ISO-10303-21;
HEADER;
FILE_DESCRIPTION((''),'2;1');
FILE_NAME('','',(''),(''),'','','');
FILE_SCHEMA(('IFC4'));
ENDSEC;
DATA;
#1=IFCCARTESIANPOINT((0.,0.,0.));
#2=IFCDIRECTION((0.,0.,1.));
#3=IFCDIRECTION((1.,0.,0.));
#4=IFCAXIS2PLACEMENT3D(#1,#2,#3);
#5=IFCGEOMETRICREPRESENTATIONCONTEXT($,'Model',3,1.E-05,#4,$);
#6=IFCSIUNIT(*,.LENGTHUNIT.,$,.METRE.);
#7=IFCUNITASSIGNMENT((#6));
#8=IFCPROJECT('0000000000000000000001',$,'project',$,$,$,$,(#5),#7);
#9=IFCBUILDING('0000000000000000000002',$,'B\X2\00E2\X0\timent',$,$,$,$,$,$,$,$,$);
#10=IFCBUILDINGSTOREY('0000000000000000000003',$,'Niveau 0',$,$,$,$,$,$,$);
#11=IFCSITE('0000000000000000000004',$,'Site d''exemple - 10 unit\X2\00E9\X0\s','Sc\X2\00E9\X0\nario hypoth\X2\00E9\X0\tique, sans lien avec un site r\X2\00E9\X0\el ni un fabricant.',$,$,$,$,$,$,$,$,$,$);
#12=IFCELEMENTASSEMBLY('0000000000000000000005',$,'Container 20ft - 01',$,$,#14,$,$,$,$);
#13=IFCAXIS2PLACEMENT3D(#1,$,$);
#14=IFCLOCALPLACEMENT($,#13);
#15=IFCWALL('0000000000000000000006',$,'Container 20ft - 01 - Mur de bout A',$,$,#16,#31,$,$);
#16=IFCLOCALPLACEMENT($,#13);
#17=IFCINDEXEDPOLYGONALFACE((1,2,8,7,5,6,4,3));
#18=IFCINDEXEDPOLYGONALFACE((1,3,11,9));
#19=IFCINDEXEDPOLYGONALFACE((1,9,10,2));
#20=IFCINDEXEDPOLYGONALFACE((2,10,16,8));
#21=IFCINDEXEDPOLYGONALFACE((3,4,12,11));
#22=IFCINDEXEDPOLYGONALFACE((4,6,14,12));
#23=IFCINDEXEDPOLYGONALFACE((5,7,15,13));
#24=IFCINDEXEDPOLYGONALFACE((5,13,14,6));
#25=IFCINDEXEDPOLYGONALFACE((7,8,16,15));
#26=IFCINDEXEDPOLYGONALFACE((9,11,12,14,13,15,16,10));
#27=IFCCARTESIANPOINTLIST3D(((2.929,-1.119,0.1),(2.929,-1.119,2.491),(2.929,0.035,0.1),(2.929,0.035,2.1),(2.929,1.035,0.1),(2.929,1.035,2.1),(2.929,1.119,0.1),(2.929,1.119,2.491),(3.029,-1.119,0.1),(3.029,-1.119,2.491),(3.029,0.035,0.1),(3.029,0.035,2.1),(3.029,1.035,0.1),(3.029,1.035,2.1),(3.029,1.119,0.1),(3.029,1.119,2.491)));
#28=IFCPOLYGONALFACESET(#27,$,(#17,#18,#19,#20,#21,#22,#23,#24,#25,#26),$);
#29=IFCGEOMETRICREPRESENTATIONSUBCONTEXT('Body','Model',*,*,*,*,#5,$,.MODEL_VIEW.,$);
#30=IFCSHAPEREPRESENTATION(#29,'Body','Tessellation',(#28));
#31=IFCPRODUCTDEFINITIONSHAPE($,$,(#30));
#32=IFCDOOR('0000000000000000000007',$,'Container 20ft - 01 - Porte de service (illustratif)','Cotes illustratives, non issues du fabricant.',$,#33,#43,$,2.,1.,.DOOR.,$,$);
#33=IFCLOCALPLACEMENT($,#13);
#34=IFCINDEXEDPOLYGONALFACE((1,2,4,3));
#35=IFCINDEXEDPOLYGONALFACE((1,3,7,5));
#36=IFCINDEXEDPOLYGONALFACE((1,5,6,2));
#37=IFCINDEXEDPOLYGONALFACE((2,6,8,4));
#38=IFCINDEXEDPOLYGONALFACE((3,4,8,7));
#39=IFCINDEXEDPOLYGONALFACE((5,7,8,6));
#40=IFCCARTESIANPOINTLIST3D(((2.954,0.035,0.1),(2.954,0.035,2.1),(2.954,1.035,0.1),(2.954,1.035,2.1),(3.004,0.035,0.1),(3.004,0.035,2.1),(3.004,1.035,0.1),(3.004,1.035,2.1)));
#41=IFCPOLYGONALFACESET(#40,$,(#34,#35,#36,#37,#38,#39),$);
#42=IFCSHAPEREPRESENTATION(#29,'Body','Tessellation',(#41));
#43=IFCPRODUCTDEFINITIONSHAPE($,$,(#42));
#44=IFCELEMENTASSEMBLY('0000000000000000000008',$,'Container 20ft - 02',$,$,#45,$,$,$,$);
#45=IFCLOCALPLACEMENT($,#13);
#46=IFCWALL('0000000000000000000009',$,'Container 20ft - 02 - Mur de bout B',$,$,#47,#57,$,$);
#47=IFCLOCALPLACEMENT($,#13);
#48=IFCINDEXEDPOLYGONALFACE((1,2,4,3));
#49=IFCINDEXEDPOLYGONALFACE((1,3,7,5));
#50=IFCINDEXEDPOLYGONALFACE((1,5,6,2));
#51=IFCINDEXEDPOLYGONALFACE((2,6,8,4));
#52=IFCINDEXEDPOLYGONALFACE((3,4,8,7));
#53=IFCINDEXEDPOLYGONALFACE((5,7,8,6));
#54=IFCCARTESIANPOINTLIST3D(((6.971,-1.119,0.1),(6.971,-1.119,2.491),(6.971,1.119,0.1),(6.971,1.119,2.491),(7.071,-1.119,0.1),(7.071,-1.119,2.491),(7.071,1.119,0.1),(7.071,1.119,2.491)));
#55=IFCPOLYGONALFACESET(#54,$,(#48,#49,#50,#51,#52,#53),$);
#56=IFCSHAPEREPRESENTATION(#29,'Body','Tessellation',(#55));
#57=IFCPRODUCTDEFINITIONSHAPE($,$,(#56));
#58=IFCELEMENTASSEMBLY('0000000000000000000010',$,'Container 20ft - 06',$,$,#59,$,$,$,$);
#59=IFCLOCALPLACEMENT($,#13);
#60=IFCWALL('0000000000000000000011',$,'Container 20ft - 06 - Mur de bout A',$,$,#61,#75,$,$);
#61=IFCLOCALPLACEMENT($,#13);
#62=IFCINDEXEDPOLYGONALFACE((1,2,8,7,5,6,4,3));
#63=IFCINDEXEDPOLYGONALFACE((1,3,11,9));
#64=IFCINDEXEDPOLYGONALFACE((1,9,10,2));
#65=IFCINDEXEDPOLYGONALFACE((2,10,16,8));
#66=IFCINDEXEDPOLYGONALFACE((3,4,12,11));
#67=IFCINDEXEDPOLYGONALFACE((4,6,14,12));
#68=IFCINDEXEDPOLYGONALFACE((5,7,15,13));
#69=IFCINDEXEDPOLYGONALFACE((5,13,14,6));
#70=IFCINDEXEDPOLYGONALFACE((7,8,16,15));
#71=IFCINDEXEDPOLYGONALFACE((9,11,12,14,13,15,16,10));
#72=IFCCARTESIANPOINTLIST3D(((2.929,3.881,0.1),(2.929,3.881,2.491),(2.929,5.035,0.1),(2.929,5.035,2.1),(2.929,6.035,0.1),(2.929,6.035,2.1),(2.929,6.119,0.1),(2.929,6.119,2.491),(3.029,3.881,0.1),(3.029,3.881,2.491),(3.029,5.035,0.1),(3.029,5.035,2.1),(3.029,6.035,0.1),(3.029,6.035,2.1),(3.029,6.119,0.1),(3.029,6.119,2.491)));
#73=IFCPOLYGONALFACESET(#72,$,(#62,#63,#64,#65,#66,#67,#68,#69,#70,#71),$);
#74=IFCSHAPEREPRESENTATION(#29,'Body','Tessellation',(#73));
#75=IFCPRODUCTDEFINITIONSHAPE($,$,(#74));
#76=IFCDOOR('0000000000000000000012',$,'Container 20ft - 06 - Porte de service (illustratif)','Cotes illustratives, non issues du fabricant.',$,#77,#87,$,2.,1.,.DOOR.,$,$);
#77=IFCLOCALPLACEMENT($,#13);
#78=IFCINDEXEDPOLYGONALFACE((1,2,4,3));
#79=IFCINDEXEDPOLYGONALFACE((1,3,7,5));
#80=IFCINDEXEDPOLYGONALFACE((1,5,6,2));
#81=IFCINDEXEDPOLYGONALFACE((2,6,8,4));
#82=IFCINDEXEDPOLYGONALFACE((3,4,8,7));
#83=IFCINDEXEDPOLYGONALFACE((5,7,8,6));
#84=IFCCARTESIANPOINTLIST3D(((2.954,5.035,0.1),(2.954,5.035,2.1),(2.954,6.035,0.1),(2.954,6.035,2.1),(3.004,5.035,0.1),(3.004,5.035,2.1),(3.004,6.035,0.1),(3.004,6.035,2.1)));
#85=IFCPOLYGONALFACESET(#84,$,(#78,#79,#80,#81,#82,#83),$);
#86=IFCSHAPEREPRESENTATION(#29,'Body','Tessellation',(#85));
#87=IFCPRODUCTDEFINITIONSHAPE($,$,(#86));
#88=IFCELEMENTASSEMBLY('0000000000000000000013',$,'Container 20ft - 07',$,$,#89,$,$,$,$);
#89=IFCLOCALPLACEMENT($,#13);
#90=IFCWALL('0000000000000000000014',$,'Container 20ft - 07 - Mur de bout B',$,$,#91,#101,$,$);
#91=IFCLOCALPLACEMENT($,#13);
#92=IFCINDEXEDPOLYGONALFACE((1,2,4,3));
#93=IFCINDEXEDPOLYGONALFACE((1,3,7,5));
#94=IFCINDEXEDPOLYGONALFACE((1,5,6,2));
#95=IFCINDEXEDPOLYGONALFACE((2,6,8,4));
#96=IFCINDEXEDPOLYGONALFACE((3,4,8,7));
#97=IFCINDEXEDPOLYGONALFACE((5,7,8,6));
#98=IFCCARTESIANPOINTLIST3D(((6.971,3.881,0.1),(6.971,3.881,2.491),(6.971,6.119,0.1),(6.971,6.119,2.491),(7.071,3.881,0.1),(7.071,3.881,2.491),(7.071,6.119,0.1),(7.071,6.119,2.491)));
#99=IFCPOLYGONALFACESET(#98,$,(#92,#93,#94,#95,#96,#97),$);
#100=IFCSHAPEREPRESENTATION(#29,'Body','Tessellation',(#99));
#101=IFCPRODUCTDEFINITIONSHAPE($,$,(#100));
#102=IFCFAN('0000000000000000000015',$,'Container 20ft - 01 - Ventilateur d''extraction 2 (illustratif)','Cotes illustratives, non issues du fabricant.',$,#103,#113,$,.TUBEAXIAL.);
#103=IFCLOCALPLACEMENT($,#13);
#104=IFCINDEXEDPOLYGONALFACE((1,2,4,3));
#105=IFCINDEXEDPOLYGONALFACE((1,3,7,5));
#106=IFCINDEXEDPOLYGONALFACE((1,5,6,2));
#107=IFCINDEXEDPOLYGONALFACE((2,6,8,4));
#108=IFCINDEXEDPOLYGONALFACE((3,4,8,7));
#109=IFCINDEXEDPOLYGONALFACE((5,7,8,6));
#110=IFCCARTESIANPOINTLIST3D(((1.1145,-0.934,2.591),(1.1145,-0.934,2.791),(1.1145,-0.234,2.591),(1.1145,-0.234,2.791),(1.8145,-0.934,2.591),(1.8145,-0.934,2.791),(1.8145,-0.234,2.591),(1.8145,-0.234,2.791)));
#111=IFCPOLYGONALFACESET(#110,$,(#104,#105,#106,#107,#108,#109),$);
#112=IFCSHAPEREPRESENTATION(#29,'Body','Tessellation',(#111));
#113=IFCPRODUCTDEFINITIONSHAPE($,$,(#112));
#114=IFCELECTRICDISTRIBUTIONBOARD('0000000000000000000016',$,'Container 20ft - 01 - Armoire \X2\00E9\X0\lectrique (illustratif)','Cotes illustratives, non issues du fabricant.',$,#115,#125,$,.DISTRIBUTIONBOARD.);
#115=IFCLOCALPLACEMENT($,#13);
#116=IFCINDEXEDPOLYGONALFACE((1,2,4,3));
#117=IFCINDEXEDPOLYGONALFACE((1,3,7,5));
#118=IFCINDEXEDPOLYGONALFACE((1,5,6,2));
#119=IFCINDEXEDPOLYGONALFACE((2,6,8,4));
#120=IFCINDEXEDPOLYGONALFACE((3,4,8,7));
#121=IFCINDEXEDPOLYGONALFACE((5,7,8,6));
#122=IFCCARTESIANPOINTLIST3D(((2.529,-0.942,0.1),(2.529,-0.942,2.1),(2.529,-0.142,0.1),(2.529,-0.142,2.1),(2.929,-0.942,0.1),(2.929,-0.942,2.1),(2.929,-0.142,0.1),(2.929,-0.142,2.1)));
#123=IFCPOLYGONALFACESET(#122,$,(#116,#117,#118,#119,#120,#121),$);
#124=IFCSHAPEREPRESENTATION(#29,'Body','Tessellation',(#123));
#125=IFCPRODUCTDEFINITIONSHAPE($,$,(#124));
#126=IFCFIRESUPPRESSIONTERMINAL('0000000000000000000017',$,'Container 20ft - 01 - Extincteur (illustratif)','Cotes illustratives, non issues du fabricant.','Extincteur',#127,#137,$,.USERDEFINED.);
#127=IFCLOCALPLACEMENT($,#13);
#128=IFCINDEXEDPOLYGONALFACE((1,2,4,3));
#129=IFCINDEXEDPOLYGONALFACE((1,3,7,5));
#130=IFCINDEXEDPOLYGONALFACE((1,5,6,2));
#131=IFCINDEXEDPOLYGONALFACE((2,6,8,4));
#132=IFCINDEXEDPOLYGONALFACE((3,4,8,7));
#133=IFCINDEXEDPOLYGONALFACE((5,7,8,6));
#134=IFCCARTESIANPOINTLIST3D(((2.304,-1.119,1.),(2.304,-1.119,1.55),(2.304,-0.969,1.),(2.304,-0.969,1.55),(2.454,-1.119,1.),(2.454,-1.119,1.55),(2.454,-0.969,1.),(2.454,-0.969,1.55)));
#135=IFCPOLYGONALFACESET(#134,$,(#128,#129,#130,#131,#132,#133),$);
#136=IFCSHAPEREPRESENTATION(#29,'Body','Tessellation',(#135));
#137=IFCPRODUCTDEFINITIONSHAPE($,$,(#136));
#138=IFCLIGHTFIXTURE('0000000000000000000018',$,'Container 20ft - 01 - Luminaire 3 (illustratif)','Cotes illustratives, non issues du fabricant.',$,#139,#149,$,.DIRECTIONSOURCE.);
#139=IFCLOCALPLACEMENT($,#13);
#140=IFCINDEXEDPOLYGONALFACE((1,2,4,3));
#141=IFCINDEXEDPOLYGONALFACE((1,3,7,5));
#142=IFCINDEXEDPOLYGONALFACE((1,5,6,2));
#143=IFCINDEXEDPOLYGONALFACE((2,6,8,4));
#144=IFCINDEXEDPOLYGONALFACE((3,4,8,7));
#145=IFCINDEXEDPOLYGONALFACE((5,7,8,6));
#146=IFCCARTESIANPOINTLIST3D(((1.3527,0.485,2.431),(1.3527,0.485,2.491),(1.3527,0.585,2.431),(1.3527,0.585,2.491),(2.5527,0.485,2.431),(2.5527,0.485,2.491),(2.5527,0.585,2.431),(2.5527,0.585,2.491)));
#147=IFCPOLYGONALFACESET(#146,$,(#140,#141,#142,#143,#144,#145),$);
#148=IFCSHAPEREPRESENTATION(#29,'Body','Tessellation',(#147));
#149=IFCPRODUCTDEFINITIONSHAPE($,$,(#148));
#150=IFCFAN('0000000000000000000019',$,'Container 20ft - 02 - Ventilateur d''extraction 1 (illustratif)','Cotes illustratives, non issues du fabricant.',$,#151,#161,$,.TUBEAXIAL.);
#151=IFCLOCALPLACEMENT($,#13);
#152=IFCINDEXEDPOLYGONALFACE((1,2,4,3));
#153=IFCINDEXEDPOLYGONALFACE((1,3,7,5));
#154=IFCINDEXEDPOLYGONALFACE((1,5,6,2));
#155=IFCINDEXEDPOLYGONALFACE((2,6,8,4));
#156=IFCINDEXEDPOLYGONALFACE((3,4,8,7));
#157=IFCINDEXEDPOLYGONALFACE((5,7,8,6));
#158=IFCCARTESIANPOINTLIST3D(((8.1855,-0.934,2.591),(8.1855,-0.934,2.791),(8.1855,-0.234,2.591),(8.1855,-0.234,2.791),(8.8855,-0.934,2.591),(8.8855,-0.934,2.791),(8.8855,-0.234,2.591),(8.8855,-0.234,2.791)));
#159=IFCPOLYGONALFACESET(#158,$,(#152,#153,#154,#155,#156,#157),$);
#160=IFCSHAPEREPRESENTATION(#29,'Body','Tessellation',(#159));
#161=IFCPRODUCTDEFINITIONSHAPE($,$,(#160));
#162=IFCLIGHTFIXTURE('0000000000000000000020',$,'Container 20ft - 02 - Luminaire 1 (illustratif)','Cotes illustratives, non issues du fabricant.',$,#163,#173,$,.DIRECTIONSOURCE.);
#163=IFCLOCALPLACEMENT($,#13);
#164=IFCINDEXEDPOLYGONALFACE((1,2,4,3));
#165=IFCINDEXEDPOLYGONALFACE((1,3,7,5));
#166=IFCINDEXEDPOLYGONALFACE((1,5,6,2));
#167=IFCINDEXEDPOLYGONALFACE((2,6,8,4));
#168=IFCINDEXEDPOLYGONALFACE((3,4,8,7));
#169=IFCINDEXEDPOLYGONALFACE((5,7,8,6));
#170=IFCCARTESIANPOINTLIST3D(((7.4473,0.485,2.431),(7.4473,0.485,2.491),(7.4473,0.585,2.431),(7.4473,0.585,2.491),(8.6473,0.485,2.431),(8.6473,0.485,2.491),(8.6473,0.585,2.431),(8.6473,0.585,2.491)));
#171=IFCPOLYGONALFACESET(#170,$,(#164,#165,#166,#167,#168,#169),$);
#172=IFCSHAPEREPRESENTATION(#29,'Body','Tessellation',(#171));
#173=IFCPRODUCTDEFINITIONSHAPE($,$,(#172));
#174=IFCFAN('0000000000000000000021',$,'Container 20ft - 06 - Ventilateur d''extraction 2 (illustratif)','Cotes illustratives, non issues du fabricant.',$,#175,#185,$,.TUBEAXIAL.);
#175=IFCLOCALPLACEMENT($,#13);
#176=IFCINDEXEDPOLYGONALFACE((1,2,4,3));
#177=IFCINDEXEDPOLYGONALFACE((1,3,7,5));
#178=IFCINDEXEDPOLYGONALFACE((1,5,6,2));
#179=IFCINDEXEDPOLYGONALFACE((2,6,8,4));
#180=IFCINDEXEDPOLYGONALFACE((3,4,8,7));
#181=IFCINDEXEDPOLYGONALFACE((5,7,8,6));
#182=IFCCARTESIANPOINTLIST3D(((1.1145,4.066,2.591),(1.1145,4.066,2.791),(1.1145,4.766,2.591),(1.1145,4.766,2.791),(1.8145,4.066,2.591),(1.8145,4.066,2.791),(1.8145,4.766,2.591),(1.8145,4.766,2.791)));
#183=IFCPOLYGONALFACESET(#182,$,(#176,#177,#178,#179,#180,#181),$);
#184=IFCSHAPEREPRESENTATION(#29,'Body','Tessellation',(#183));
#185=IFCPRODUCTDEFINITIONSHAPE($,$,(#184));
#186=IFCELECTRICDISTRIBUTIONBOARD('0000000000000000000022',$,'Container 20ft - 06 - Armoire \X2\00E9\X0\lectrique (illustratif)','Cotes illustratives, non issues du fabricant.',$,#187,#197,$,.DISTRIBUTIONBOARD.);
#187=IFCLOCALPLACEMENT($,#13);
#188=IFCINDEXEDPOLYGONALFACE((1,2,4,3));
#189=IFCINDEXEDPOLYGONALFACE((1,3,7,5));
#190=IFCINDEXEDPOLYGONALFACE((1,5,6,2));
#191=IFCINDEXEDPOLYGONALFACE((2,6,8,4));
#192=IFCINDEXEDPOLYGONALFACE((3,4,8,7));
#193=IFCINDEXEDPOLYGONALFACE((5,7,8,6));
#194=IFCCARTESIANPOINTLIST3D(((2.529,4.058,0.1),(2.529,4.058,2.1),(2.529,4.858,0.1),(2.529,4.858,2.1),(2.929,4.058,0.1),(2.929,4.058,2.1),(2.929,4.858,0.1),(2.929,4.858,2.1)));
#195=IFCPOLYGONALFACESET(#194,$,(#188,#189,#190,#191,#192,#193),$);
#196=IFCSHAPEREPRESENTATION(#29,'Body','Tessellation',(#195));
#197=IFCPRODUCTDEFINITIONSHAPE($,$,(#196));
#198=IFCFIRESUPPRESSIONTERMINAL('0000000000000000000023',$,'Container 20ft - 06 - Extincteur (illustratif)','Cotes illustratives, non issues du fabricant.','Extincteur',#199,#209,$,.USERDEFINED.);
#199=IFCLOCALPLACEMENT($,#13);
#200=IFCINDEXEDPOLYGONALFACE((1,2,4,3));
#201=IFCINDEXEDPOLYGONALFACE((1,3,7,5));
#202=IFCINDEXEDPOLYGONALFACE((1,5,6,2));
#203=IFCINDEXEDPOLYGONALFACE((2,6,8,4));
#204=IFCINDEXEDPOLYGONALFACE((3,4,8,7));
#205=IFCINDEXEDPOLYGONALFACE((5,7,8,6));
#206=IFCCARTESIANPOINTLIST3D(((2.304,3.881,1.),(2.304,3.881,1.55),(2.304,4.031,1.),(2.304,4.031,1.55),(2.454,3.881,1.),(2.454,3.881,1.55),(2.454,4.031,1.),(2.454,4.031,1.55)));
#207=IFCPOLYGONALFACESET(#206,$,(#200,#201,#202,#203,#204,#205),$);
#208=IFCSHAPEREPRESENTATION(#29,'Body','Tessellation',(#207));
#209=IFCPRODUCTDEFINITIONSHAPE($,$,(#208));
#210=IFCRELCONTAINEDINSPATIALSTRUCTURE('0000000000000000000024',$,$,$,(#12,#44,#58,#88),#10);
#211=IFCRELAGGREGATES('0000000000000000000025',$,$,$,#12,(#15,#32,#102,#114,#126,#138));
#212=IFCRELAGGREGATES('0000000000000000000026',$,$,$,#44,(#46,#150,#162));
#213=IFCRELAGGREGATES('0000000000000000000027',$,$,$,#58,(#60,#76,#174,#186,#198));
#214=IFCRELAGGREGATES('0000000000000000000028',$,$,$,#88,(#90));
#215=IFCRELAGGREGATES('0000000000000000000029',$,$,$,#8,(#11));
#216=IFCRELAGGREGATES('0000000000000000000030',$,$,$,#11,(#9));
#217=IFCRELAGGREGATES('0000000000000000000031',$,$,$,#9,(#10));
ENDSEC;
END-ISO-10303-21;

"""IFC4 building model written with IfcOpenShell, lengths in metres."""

from ifc_helpers import new_model, si_unit, frame, origin_with_axes, place, context, subcontext, project, spatial, rectangle, extrude, element, fill, aggregate, save


model = new_model("IFC4")

# Units and contexts
model_context = context("Model", 3, precision=1e-05, world=origin_with_axes())
body_context = subcontext(model_context, "Body", "Model", "MODEL_VIEW")
ifc_project = project(units=[si_unit("LENGTHUNIT", "METRE")], contexts=[model_context])

# Site, building, storey
site = spatial("IfcSite", under=ifc_project, Name="Site d'exemple - 10 unités", Description="Scénario hypothétique, sans lien avec un site réel ni un fabricant.")
building = spatial("IfcBuilding", under=site, Name="Bâtiment")
storey = spatial("IfcBuildingStorey", under=building, Name="Niveau 0")

# Element assembly, wall, opening, door
assembly_1 = element("IfcElementAssembly", 1, inside=storey, Name="Container 20ft - 01")
wall_1_placement = place(None, frame((2.979, 0.0, 0.1), z_axis=(0.0, 0.0, 1.0), x_axis=(1.0, 0.0, 0.0)))
wall_1 = element("IfcWall", 2, at=wall_1_placement, Name="Container 20ft - 01 - Mur de bout A", context=body_context, shape_type="SweptSolid", body=[
    extrude(rectangle(XDim=0.1, YDim=2.238), origin_with_axes(), (0.0, 0.0, 1.0), 2.391),
])
opening_1_placement = place(None, frame((2.979, 0.535, 0.1), z_axis=(0.0, 0.0, 1.0), x_axis=(1.0, 0.0, 0.0)))
opening_1 = element("IfcOpeningElement", 3, at=opening_1_placement, cuts=wall_1, PredefinedType="OPENING", context=body_context, shape_type="SweptSolid", body=[
    extrude(rectangle(XDim=0.2, YDim=1.0), origin_with_axes(), (0.0, 0.0, 1.0), 2.0),
])
door_1_placement = place(None, frame((2.979, 0.535, 0.1), z_axis=(0.0, 0.0, 1.0), x_axis=(1.0, 0.0, 0.0)))
door_1 = element("IfcDoor", 4, at=door_1_placement, Name="Container 20ft - 01 - Porte de service (illustratif)", Description="Cotes illustratives, non issues du fabricant.", OverallHeight=2.0, OverallWidth=1.0, PredefinedType="DOOR", context=body_context, shape_type="SweptSolid", body=[
    extrude(rectangle(XDim=0.05, YDim=1.0), origin_with_axes(), (0.0, 0.0, 1.0), 2.0),
])
fill(opening_1, door_1)

# Element assembly, wall
assembly_2 = element("IfcElementAssembly", 5, inside=storey, Name="Container 20ft - 02")
wall_2_placement = place(None, frame((7.021, 0.0, 0.1), z_axis=(0.0, 0.0, 1.0), x_axis=(1.0, 0.0, 0.0)))
wall_2 = element("IfcWall", 6, at=wall_2_placement, Name="Container 20ft - 02 - Mur de bout B", context=body_context, shape_type="SweptSolid", body=[
    extrude(rectangle(XDim=0.1, YDim=2.238), origin_with_axes(), (0.0, 0.0, 1.0), 2.391),
])

# Element assembly, wall, opening, door
assembly_3 = element("IfcElementAssembly", 7, inside=storey, Name="Container 20ft - 06")
wall_3_placement = place(None, frame((2.979, 5.0, 0.1), z_axis=(0.0, 0.0, 1.0), x_axis=(1.0, 0.0, 0.0)))
wall_3 = element("IfcWall", 8, at=wall_3_placement, Name="Container 20ft - 06 - Mur de bout A", context=body_context, shape_type="SweptSolid", body=[
    extrude(rectangle(XDim=0.1, YDim=2.238), origin_with_axes(), (0.0, 0.0, 1.0), 2.391),
])
opening_2_placement = place(None, frame((2.979, 5.535, 0.1), z_axis=(0.0, 0.0, 1.0), x_axis=(1.0, 0.0, 0.0)))
opening_2 = element("IfcOpeningElement", 9, at=opening_2_placement, cuts=wall_3, PredefinedType="OPENING", context=body_context, shape_type="SweptSolid", body=[
    extrude(rectangle(XDim=0.2, YDim=1.0), origin_with_axes(), (0.0, 0.0, 1.0), 2.0),
])
door_2_placement = place(None, frame((2.979, 5.535, 0.1), z_axis=(0.0, 0.0, 1.0), x_axis=(1.0, 0.0, 0.0)))
door_2 = element("IfcDoor", 10, at=door_2_placement, Name="Container 20ft - 06 - Porte de service (illustratif)", Description="Cotes illustratives, non issues du fabricant.", OverallHeight=2.0, OverallWidth=1.0, PredefinedType="DOOR", context=body_context, shape_type="SweptSolid", body=[
    extrude(rectangle(XDim=0.05, YDim=1.0), origin_with_axes(), (0.0, 0.0, 1.0), 2.0),
])
fill(opening_2, door_2)

# Element assembly, wall
assembly_4 = element("IfcElementAssembly", 11, inside=storey, Name="Container 20ft - 07")
wall_4_placement = place(None, frame((7.021, 5.0, 0.1), z_axis=(0.0, 0.0, 1.0), x_axis=(1.0, 0.0, 0.0)))
wall_4 = element("IfcWall", 12, at=wall_4_placement, Name="Container 20ft - 07 - Mur de bout B", context=body_context, shape_type="SweptSolid", body=[
    extrude(rectangle(XDim=0.1, YDim=2.238), origin_with_axes(), (0.0, 0.0, 1.0), 2.391),
])

# Fan
fan_1_placement = place(None, frame((1.4645, -0.584, 2.591), z_axis=(0.0, 0.0, 1.0), x_axis=(1.0, 0.0, 0.0)))
fan_1 = element("IfcFan", 13, at=fan_1_placement, Name="Container 20ft - 01 - Ventilateur d'extraction 2 (illustratif)", Description="Cotes illustratives, non issues du fabricant.", PredefinedType="TUBEAXIAL", context=body_context, shape_type="SweptSolid", body=[
    extrude(rectangle(XDim=0.7, YDim=0.7), origin_with_axes(), (0.0, 0.0, 1.0), 0.2),
])

# Electric distribution board
electric_distribution_board_1_placement = place(None, frame((2.729, -0.542, 0.1), z_axis=(0.0, 0.0, 1.0), x_axis=(1.0, 0.0, 0.0)))
electric_distribution_board_1 = element("IfcElectricDistributionBoard", 14, at=electric_distribution_board_1_placement, Name="Container 20ft - 01 - Armoire électrique (illustratif)", Description="Cotes illustratives, non issues du fabricant.", PredefinedType="DISTRIBUTIONBOARD", context=body_context, shape_type="SweptSolid", body=[
    extrude(rectangle(XDim=0.4, YDim=0.8), origin_with_axes(), (0.0, 0.0, 1.0), 2.0),
])

# Fire suppression terminal
fire_suppression_terminal_1_placement = place(None, frame((2.379, -1.044, 1.0), z_axis=(0.0, 0.0, 1.0), x_axis=(1.0, 0.0, 0.0)))
fire_suppression_terminal_1 = element("IfcFireSuppressionTerminal", 15, at=fire_suppression_terminal_1_placement, Name="Container 20ft - 01 - Extincteur (illustratif)", Description="Cotes illustratives, non issues du fabricant.", ObjectType="Extincteur", PredefinedType="USERDEFINED", context=body_context, shape_type="SweptSolid", body=[
    extrude(rectangle(XDim=0.15, YDim=0.15), origin_with_axes(), (0.0, 0.0, 1.0), 0.55),
])

# Light fixture
light_fixture_1_placement = place(None, frame((1.9527, 0.535, 2.431), z_axis=(0.0, 0.0, 1.0), x_axis=(1.0, 0.0, 0.0)))
light_fixture_1 = element("IfcLightFixture", 16, at=light_fixture_1_placement, Name="Container 20ft - 01 - Luminaire 3 (illustratif)", Description="Cotes illustratives, non issues du fabricant.", PredefinedType="DIRECTIONSOURCE", context=body_context, shape_type="SweptSolid", body=[
    extrude(rectangle(XDim=1.2, YDim=0.1), origin_with_axes(), (0.0, 0.0, 1.0), 0.06),
])

# Fan
fan_2_placement = place(None, frame((8.5355, -0.584, 2.591), z_axis=(0.0, 0.0, 1.0), x_axis=(1.0, 0.0, 0.0)))
fan_2 = element("IfcFan", 17, at=fan_2_placement, Name="Container 20ft - 02 - Ventilateur d'extraction 1 (illustratif)", Description="Cotes illustratives, non issues du fabricant.", PredefinedType="TUBEAXIAL", context=body_context, shape_type="SweptSolid", body=[
    extrude(rectangle(XDim=0.7, YDim=0.7), origin_with_axes(), (0.0, 0.0, 1.0), 0.2),
])

# Light fixture
light_fixture_2_placement = place(None, frame((8.0473, 0.535, 2.431), z_axis=(0.0, 0.0, 1.0), x_axis=(1.0, 0.0, 0.0)))
light_fixture_2 = element("IfcLightFixture", 18, at=light_fixture_2_placement, Name="Container 20ft - 02 - Luminaire 1 (illustratif)", Description="Cotes illustratives, non issues du fabricant.", PredefinedType="DIRECTIONSOURCE", context=body_context, shape_type="SweptSolid", body=[
    extrude(rectangle(XDim=1.2, YDim=0.1), origin_with_axes(), (0.0, 0.0, 1.0), 0.06),
])

# Fan
fan_3_placement = place(None, frame((1.4645, 4.416, 2.591), z_axis=(0.0, 0.0, 1.0), x_axis=(1.0, 0.0, 0.0)))
fan_3 = element("IfcFan", 19, at=fan_3_placement, Name="Container 20ft - 06 - Ventilateur d'extraction 2 (illustratif)", Description="Cotes illustratives, non issues du fabricant.", PredefinedType="TUBEAXIAL", context=body_context, shape_type="SweptSolid", body=[
    extrude(rectangle(XDim=0.7, YDim=0.7), origin_with_axes(), (0.0, 0.0, 1.0), 0.2),
])

# Electric distribution board
electric_distribution_board_2_placement = place(None, frame((2.729, 4.458, 0.1), z_axis=(0.0, 0.0, 1.0), x_axis=(1.0, 0.0, 0.0)))
electric_distribution_board_2 = element("IfcElectricDistributionBoard", 20, at=electric_distribution_board_2_placement, Name="Container 20ft - 06 - Armoire électrique (illustratif)", Description="Cotes illustratives, non issues du fabricant.", PredefinedType="DISTRIBUTIONBOARD", context=body_context, shape_type="SweptSolid", body=[
    extrude(rectangle(XDim=0.4, YDim=0.8), origin_with_axes(), (0.0, 0.0, 1.0), 2.0),
])

# Fire suppression terminal
fire_suppression_terminal_2_placement = place(None, frame((2.379, 3.956, 1.0), z_axis=(0.0, 0.0, 1.0), x_axis=(1.0, 0.0, 0.0)))
fire_suppression_terminal_2 = element("IfcFireSuppressionTerminal", 21, at=fire_suppression_terminal_2_placement, Name="Container 20ft - 06 - Extincteur (illustratif)", Description="Cotes illustratives, non issues du fabricant.", ObjectType="Extincteur", PredefinedType="USERDEFINED", context=body_context, shape_type="SweptSolid", body=[
    extrude(rectangle(XDim=0.15, YDim=0.15), origin_with_axes(), (0.0, 0.0, 1.0), 0.55),
])

aggregate(assembly_1, [wall_1, door_1, fan_1, electric_distribution_board_1, fire_suppression_terminal_1, light_fixture_1])
aggregate(assembly_2, [wall_2, fan_2, light_fixture_2])
aggregate(assembly_3, [wall_3, door_2, fan_3, electric_distribution_board_2, fire_suppression_terminal_2])
aggregate(assembly_4, [wall_4])

save(model, "model.ifc")
